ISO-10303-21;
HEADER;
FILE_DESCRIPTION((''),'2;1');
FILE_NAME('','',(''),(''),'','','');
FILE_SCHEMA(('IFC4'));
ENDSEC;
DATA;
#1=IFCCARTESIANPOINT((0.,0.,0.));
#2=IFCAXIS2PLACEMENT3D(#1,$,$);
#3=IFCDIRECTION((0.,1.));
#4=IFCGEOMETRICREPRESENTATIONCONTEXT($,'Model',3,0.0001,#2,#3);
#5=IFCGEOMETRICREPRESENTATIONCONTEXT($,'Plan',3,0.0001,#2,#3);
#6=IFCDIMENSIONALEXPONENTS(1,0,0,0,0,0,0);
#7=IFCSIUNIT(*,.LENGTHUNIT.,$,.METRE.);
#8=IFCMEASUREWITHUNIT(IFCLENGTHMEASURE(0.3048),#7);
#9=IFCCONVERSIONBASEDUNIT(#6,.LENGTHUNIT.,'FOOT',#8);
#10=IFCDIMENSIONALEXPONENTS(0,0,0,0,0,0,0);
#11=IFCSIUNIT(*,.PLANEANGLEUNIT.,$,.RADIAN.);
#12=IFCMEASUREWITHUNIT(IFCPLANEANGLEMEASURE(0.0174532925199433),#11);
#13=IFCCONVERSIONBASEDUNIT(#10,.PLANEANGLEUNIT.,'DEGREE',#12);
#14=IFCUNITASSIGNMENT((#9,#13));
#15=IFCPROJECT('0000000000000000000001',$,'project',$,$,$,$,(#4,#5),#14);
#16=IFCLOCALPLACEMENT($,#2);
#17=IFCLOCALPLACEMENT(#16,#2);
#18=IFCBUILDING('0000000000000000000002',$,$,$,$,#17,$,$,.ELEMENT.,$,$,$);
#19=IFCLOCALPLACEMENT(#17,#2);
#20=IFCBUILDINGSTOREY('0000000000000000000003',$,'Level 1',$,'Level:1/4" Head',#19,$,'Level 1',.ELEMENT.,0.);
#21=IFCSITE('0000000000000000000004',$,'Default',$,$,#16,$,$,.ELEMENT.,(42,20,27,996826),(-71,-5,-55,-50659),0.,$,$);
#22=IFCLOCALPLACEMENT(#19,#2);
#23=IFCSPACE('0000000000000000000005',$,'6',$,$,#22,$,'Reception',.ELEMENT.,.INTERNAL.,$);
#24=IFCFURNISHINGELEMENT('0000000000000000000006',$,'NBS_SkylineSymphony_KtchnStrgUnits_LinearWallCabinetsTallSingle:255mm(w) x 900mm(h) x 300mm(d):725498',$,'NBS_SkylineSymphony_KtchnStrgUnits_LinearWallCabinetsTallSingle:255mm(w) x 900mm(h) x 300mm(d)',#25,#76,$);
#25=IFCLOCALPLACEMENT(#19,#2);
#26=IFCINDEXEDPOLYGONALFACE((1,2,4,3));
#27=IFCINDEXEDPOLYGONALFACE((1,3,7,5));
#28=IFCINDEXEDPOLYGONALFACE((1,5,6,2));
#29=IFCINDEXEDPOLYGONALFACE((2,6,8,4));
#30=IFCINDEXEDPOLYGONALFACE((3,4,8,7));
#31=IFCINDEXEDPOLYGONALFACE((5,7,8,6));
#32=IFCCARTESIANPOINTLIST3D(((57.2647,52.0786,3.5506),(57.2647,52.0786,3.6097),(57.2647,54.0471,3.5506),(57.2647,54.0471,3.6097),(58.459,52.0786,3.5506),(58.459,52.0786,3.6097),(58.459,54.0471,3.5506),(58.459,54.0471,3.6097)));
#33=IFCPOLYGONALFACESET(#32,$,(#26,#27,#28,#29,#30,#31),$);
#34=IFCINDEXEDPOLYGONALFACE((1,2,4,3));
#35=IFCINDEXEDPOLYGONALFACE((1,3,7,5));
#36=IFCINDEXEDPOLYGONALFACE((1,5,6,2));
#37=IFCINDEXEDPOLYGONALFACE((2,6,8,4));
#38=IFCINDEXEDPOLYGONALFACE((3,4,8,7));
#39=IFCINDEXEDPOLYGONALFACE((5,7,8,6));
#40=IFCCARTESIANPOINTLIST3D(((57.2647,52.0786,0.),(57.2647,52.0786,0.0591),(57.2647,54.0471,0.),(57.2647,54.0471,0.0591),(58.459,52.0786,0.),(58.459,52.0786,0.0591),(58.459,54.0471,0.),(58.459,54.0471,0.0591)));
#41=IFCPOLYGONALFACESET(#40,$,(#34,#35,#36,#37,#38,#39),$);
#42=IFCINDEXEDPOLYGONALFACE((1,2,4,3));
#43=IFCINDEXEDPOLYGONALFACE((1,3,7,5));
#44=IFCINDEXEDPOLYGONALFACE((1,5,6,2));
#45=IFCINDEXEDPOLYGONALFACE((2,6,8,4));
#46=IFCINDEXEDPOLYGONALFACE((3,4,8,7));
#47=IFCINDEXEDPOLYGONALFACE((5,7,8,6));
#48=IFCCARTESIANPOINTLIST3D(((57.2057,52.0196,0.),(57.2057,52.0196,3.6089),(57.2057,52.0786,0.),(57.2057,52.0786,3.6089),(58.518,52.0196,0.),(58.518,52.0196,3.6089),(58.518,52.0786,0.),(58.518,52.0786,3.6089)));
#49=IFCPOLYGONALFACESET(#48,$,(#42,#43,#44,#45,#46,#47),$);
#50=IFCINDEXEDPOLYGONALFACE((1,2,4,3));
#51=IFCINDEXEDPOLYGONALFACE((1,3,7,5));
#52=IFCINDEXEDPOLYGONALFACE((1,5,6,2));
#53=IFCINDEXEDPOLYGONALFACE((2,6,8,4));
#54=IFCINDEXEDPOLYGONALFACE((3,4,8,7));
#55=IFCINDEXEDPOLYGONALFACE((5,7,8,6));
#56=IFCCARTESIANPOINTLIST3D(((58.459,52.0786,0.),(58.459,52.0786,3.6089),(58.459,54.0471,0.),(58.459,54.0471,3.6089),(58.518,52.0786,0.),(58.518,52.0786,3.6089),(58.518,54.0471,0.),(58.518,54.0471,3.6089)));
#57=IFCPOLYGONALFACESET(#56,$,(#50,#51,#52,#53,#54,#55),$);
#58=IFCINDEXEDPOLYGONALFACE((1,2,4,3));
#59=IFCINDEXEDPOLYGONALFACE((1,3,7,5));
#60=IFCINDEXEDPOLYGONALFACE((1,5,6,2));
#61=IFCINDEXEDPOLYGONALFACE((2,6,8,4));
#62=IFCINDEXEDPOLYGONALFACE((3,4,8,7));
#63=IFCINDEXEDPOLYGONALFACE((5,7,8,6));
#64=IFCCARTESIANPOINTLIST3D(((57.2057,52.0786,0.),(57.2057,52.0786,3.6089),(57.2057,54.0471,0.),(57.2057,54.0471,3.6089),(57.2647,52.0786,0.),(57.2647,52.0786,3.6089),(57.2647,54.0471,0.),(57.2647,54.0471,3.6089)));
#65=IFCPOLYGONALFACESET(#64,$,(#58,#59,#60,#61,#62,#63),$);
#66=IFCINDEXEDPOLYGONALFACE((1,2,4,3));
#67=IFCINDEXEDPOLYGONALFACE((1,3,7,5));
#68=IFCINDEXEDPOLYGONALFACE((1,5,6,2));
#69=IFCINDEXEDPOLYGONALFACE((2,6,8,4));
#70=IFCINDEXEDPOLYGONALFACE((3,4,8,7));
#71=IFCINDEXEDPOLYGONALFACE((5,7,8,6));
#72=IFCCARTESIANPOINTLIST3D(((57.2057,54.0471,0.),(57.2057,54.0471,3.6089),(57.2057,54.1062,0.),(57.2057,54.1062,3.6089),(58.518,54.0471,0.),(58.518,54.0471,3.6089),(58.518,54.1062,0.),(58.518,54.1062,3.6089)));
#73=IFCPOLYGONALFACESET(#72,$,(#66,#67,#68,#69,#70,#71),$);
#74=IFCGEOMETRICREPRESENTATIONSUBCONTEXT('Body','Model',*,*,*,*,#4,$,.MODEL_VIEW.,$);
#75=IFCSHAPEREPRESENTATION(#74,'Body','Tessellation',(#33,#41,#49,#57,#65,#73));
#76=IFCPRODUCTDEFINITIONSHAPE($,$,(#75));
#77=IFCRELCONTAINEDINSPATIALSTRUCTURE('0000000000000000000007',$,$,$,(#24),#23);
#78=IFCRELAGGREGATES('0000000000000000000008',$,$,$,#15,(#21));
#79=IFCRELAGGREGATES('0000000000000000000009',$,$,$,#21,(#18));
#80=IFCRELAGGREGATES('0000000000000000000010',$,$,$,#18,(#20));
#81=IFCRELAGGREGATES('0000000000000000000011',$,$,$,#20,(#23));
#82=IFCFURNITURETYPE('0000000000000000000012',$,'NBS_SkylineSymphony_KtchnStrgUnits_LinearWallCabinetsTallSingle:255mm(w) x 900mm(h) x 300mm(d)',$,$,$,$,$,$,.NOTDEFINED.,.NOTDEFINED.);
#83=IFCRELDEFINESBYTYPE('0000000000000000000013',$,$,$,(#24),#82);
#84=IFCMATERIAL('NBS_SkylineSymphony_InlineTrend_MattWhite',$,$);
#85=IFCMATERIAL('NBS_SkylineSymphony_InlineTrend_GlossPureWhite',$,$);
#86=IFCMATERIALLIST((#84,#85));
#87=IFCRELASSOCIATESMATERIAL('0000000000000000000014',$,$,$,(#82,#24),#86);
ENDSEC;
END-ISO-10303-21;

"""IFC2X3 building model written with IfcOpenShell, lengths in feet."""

from ifc_helpers import new_model, entity, si_unit, converted_unit, direction, frame, frame_2d, origin, origin_2d_with_axis, place, context, subcontext, project, spatial, rectangle, extrude, source, transform, mapped, material, material_list, type_object, type_shapes, element, save


model = new_model("IFC2X3")

# Units and contexts
model_context = context("Model", 3, precision=0.0001, world=origin(), true_north=direction((0.0, 1.0)))
plan_context = context("Plan", 3, precision=0.0001, world=origin(), true_north=direction((0.0, 1.0)))
body_context = subcontext(model_context, "Body", "Model", "MODEL_VIEW")
ifc_project = project(units=[converted_unit("LENGTHUNIT", "FOOT", entity("IfcLengthMeasure", 0.3048), si_unit("LENGTHUNIT", "METRE"), dimensions=[1, 0, 0, 0, 0, 0, 0]), converted_unit("PLANEANGLEUNIT", "DEGREE", entity("IfcPlaneAngleMeasure", 0.0174532925199433), si_unit("PLANEANGLEUNIT", "RADIAN"), dimensions=[0, 0, 0, 0, 0, 0, 0])], contexts=[model_context, plan_context])

# Site, building, storey
site_placement = place(None, origin())
site = spatial("IfcSite", under=ifc_project, at=site_placement, Name="Default", CompositionType="ELEMENT", RefLatitude=(42, 20, 27, 996826), RefLongitude=(-71, -5, -55, -50659), RefElevation=0.0)
building_placement = place(site_placement, origin())
building = spatial("IfcBuilding", under=site, at=building_placement, CompositionType="ELEMENT")
storey_placement = place(building_placement, origin())
storey = spatial("IfcBuildingStorey", under=building, at=storey_placement, Name="Level 1", ObjectType="Level:1/4\" Head", LongName="Level 1", CompositionType="ELEMENT", Elevation=0.0)

# Shared definitions
space_1_placement = place(storey_placement, origin())
space_1 = spatial("IfcSpace", under=storey, at=space_1_placement, Name="6", LongName="Reception", CompositionType="ELEMENT", InteriorOrExteriorSpace="INTERNAL")

# Furnishing element
ifc_material_1 = material(Name="NBS_SkylineSymphony_InlineTrend_MattWhite")
ifc_material_2 = material(Name="NBS_SkylineSymphony_InlineTrend_GlossPureWhite")
ifc_material_list = material_list([ifc_material_1, ifc_material_2])
furniture_type_1 = type_object("IfcFurnitureType", Name="NBS_SkylineSymphony_KtchnStrgUnits_LinearWallCabinetsTallSingle:255mm(w) x 900mm(h) x 300mm(d)", AssemblyPlace="NOTDEFINED", material=ifc_material_list)
shared_shape_1 = source(origin(), body_context, "Body", "SweptSolid", [
    extrude(rectangle(XDim=1.9685, YDim=1.1942, at=origin_2d_with_axis()), frame((-0.2379, 0.0, 3.5506), z_axis=(0.0, 0.0, 1.0), x_axis=(0.0, 1.0, 0.0)), (0.0, 0.0, 1.0), 0.0591),
    extrude(rectangle(XDim=1.9685, YDim=1.1942, at=origin_2d_with_axis()), frame((-0.2379, 0.0, 0.0), z_axis=(0.0, 0.0, 1.0), x_axis=(0.0, 1.0, 0.0)), (0.0, 0.0, 1.0), 0.0591),
    extrude(rectangle(XDim=1.3123, YDim=0.0591, at=origin_2d_with_axis()), frame((-0.2379, 1.0138, 0.0), z_axis=(0.0, 0.0, 1.0), x_axis=(-1.0, 0.0, 0.0)), (0.0, 0.0, 1.0), 3.6089),
    extrude(rectangle(XDim=1.9685, YDim=0.0591, at=origin_2d_with_axis()), frame((-0.8645, 0.0, 0.0), z_axis=(0.0, 0.0, 1.0), x_axis=(0.0, -1.0, 0.0)), (0.0, 0.0, 1.0), 3.6089),
    extrude(rectangle(XDim=0.0591, YDim=1.9685, at=origin_2d_with_axis()), frame((0.3888, 0.0, 0.0)), (0.0, 0.0, 1.0), 3.6089),
    extrude(rectangle(XDim=0.0591, YDim=1.3123, at=frame_2d((0.0, 0.0), x_axis=(1.0, 0.0))), frame((-0.2379, -1.0138, 0.0), z_axis=(0.0, 0.0, 1.0), x_axis=(0.0, 1.0, 0.0)), (0.0, 0.0, 1.0), 3.6089),
])
type_shapes(furniture_type_1, [shared_shape_1])
for number, where, z_axis, x_axis, name in (
    (1, (57.624, 53.0629, 0.0), (0.0, 0.0, 1.0), (-1.0, 0.0, 0.0), "NBS_SkylineSymphony_KtchnStrgUnits_LinearWallCabinetsTallSingle:255mm(w) x 900mm(h) x 300mm(d):725498"),
):
    element("IfcFurnishingElement", number, at=place(space_1_placement, frame(where, z_axis=z_axis, x_axis=x_axis)), inside=space_1, type_object=furniture_type_1, material=ifc_material_list, Name=name, ObjectType="NBS_SkylineSymphony_KtchnStrgUnits_LinearWallCabinetsTallSingle:255mm(w) x 900mm(h) x 300mm(d)", context=body_context, shape_type="MappedRepresentation", body=[
        mapped(shared_shape_1, transform((0.0, 0.0, 0.0), scale=1.0)),
    ])

save(model, "model.ifc")
